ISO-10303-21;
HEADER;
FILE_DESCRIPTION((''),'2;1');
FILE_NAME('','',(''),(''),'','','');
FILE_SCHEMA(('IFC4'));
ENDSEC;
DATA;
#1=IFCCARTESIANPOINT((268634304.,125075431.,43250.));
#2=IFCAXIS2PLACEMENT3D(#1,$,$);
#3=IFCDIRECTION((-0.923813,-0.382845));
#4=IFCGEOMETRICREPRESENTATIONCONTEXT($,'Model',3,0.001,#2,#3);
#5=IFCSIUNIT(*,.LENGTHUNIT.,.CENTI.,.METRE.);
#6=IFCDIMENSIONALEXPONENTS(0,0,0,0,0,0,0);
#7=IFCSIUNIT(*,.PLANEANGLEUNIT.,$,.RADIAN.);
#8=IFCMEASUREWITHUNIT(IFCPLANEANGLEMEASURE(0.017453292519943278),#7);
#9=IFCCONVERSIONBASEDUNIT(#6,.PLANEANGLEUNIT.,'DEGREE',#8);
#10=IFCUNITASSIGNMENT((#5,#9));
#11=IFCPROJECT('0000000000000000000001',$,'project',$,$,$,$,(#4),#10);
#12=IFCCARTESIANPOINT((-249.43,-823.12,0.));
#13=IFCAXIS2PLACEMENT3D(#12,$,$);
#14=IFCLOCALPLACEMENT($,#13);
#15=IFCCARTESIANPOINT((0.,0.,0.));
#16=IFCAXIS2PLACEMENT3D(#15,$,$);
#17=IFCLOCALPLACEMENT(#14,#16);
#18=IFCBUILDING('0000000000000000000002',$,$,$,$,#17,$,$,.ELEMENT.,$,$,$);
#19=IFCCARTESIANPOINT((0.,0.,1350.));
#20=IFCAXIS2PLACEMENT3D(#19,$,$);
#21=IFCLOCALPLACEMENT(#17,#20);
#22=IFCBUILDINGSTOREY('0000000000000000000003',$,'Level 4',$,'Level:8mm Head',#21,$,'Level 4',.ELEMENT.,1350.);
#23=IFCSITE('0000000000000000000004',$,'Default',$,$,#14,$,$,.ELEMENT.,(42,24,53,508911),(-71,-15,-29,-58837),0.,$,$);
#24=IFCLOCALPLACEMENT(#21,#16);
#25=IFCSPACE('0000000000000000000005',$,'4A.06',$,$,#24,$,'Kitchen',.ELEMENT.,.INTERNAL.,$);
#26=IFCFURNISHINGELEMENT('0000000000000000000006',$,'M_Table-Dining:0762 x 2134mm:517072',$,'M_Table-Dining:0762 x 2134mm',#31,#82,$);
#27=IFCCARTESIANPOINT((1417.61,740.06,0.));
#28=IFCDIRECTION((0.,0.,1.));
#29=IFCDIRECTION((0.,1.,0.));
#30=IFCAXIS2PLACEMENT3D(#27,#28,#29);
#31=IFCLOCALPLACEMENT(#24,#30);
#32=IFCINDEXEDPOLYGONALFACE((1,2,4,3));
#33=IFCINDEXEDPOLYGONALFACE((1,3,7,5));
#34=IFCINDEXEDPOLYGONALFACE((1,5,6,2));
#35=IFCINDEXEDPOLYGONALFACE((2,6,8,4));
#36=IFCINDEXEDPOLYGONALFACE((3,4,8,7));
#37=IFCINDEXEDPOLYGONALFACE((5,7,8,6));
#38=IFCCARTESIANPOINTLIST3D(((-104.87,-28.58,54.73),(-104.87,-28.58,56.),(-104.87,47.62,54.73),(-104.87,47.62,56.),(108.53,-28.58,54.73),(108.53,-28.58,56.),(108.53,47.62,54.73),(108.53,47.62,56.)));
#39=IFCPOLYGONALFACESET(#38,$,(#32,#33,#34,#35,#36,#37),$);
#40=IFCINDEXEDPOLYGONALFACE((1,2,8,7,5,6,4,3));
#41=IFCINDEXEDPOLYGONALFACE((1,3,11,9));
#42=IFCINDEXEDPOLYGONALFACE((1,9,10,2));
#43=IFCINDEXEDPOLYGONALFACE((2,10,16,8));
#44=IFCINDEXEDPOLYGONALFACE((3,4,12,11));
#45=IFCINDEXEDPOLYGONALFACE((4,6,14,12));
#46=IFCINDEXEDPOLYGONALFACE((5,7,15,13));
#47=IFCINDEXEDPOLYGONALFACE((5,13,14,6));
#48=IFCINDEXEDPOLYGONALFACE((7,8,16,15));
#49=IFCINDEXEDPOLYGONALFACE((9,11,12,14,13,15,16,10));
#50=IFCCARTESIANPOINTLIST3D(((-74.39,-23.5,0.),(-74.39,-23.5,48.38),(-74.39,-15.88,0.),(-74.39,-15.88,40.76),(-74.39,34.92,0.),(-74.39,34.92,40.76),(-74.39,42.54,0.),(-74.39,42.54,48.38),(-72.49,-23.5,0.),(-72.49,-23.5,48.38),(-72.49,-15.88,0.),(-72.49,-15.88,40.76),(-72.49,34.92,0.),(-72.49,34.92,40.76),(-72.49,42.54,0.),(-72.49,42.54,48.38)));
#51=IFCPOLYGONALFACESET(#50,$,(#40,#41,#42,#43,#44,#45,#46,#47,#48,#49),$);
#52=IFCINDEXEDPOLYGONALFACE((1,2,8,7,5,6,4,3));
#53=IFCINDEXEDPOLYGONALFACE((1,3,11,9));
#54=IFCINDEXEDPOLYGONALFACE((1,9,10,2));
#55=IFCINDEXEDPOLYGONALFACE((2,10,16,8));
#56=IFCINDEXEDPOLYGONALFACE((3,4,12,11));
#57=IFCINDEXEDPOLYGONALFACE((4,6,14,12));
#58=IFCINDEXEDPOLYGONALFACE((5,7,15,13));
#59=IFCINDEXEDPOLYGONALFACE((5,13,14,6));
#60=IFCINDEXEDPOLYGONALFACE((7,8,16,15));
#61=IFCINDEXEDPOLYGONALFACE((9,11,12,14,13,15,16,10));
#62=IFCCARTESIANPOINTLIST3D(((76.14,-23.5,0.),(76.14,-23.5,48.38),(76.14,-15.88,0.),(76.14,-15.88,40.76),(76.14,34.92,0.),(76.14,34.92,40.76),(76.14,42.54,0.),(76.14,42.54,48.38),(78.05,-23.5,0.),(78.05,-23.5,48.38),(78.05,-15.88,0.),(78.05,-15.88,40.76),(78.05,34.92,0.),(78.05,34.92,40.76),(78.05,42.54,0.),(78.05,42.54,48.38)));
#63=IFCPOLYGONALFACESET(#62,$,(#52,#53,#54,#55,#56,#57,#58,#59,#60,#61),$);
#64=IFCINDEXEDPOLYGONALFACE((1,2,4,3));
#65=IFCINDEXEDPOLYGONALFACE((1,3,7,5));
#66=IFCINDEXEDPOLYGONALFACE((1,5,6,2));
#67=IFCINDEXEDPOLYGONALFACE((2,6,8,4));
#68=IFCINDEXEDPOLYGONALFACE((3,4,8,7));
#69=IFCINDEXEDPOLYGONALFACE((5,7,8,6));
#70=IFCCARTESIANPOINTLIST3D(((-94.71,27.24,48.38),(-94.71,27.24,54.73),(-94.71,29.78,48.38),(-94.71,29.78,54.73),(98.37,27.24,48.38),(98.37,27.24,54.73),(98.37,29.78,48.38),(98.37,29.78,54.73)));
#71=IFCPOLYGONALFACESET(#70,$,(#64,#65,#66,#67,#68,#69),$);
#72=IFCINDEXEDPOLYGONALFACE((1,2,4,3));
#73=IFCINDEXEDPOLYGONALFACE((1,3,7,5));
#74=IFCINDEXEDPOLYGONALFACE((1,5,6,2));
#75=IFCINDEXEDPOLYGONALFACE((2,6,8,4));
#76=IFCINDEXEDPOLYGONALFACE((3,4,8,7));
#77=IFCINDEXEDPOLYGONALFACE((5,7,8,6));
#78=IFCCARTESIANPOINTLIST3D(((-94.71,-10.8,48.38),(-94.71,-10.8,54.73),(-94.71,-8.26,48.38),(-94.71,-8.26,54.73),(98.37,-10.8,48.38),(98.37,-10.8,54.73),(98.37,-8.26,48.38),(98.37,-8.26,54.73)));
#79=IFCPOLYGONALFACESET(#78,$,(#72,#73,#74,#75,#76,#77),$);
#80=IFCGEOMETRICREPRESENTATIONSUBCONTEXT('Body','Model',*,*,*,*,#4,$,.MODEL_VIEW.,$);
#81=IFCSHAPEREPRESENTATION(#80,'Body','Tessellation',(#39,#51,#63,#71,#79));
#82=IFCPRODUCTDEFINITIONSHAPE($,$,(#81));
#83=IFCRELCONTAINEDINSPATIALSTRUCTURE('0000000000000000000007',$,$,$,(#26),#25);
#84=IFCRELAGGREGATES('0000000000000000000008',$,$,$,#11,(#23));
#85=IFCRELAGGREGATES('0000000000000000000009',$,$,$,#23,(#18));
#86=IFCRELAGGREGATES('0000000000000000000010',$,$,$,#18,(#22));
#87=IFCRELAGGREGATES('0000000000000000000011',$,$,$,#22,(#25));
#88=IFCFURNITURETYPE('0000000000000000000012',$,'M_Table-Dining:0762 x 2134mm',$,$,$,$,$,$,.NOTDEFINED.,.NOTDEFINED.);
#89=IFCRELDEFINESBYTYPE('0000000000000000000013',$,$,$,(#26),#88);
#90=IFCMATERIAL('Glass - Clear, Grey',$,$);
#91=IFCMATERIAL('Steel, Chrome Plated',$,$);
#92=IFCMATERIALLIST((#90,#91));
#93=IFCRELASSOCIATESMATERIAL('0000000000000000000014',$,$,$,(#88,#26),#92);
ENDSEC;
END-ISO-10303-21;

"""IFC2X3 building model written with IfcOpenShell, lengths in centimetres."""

from ifc_helpers import new_model, entity, si_unit, converted_unit, direction, frame, frame_2d, origin, origin_2d_with_axis, place, context, subcontext, project, spatial, polyline, rectangle, outline, extrude, source, transform, mapped, material, material_list, type_object, type_shapes, element, save


model = new_model("IFC2X3")

# Units and contexts
model_context = context("Model", 3, precision=0.001, world=frame((268634304.0, 125075431.0, 43250.0)), true_north=direction((-0.923813, -0.382845)))
body_context = subcontext(model_context, "Body", "Model", "MODEL_VIEW")
ifc_project = project(units=[si_unit("LENGTHUNIT", "METRE", prefix="CENTI"), converted_unit("PLANEANGLEUNIT", "DEGREE", entity("IfcPlaneAngleMeasure", 0.017453292519943278), si_unit("PLANEANGLEUNIT", "RADIAN"), dimensions=[0, 0, 0, 0, 0, 0, 0])], contexts=[model_context])

# Site, building, storey
site_placement = place(None, frame((-249.43, -823.12, 0.0)))
site = spatial("IfcSite", under=ifc_project, at=site_placement, Name="Default", CompositionType="ELEMENT", RefLatitude=(42, 24, 53, 508911), RefLongitude=(-71, -15, -29, -58837), RefElevation=0.0)
building_placement = place(site_placement, origin())
building = spatial("IfcBuilding", under=site, at=building_placement, CompositionType="ELEMENT")
storey_placement = place(building_placement, frame((0.0, 0.0, 1350.0)))
storey = spatial("IfcBuildingStorey", under=building, at=storey_placement, Name="Level 4", ObjectType="Level:8mm Head", LongName="Level 4", CompositionType="ELEMENT", Elevation=1350.0)

# Shared definitions
space_1_placement = place(storey_placement, origin())
space_1 = spatial("IfcSpace", under=storey, at=space_1_placement, Name="4A.06", LongName="Kitchen", CompositionType="ELEMENT", InteriorOrExteriorSpace="INTERNAL")

# Furnishing element
ifc_material_1 = material(Name="Glass - Clear, Grey")
ifc_material_2 = material(Name="Steel, Chrome Plated")
ifc_material_list_1 = material_list([ifc_material_1, ifc_material_2])
furniture_type_1 = type_object("IfcFurnitureType", Name="M_Table-Dining:0762 x 2134mm", AssemblyPlace="NOTDEFINED", material=ifc_material_list_1)
shared_shape_1 = source(origin(), body_context, "Body", "SweptSolid", [
    extrude(rectangle(XDim=213.4, YDim=76.2, at=origin_2d_with_axis()), frame((1.83, 9.52, 54.73), z_axis=(0.0, 0.0, 1.0), x_axis=(-1.0, 0.0, 0.0)), (0.0, 0.0, 1.0), 1.27),
    extrude(outline(polyline([(-33.02, -26.09), (33.02, -26.09), (33.02, 22.28), (25.4, 22.28), (25.4, -18.47), (-25.4, -18.47), (-25.4, 22.28), (-33.02, 22.28), (-33.02, -26.09)])), frame((-74.39, 9.52, 22.28), z_axis=(1.0, 0.0, 0.0), x_axis=(0.0, -1.0, 0.0)), (0.0, 0.0, 1.0), 1.91),
    extrude(outline(polyline([(-22.28, -33.02), (26.09, -33.02), (26.09, 33.02), (-22.28, 33.02), (-22.28, 25.4), (18.47, 25.4), (18.47, -25.4), (-22.28, -25.4), (-22.28, -33.02)])), frame((76.14, 9.52, 22.28), z_axis=(1.0, 0.0, 0.0), x_axis=(0.0, 0.0, 1.0)), (0.0, 0.0, 1.0), 1.91),
    extrude(rectangle(XDim=193.08, YDim=2.54, at=frame_2d((0.0, 0.0), x_axis=(1.0, 0.0))), frame((1.83, 28.51, 48.38), z_axis=(0.0, 0.0, 1.0), x_axis=(-1.0, 0.0, 0.0)), (0.0, 0.0, 1.0), 6.35),
    extrude(rectangle(XDim=193.08, YDim=2.54, at=origin_2d_with_axis()), frame((1.83, -9.53, 48.38), z_axis=(0.0, 0.0, 1.0), x_axis=(-1.0, 0.0, 0.0)), (0.0, 0.0, 1.0), 6.35),
])
type_shapes(furniture_type_1, [shared_shape_1])
furnishing_1_placement = place(space_1_placement, frame((1417.61, 740.06, 0.0), z_axis=(0.0, 0.0, 1.0), x_axis=(0.0, 1.0, 0.0)))
element("IfcFurnishingElement", 1, at=furnishing_1_placement, inside=space_1, type_object=furniture_type_1, material=ifc_material_list_1, Name="M_Table-Dining:0762 x 2134mm:517072", ObjectType="M_Table-Dining:0762 x 2134mm", context=body_context, shape_type="MappedRepresentation", body=[
    mapped(shared_shape_1, transform((0.0, 0.0, 0.0), scale=1.0)),
])

save(model, "model.ifc")
